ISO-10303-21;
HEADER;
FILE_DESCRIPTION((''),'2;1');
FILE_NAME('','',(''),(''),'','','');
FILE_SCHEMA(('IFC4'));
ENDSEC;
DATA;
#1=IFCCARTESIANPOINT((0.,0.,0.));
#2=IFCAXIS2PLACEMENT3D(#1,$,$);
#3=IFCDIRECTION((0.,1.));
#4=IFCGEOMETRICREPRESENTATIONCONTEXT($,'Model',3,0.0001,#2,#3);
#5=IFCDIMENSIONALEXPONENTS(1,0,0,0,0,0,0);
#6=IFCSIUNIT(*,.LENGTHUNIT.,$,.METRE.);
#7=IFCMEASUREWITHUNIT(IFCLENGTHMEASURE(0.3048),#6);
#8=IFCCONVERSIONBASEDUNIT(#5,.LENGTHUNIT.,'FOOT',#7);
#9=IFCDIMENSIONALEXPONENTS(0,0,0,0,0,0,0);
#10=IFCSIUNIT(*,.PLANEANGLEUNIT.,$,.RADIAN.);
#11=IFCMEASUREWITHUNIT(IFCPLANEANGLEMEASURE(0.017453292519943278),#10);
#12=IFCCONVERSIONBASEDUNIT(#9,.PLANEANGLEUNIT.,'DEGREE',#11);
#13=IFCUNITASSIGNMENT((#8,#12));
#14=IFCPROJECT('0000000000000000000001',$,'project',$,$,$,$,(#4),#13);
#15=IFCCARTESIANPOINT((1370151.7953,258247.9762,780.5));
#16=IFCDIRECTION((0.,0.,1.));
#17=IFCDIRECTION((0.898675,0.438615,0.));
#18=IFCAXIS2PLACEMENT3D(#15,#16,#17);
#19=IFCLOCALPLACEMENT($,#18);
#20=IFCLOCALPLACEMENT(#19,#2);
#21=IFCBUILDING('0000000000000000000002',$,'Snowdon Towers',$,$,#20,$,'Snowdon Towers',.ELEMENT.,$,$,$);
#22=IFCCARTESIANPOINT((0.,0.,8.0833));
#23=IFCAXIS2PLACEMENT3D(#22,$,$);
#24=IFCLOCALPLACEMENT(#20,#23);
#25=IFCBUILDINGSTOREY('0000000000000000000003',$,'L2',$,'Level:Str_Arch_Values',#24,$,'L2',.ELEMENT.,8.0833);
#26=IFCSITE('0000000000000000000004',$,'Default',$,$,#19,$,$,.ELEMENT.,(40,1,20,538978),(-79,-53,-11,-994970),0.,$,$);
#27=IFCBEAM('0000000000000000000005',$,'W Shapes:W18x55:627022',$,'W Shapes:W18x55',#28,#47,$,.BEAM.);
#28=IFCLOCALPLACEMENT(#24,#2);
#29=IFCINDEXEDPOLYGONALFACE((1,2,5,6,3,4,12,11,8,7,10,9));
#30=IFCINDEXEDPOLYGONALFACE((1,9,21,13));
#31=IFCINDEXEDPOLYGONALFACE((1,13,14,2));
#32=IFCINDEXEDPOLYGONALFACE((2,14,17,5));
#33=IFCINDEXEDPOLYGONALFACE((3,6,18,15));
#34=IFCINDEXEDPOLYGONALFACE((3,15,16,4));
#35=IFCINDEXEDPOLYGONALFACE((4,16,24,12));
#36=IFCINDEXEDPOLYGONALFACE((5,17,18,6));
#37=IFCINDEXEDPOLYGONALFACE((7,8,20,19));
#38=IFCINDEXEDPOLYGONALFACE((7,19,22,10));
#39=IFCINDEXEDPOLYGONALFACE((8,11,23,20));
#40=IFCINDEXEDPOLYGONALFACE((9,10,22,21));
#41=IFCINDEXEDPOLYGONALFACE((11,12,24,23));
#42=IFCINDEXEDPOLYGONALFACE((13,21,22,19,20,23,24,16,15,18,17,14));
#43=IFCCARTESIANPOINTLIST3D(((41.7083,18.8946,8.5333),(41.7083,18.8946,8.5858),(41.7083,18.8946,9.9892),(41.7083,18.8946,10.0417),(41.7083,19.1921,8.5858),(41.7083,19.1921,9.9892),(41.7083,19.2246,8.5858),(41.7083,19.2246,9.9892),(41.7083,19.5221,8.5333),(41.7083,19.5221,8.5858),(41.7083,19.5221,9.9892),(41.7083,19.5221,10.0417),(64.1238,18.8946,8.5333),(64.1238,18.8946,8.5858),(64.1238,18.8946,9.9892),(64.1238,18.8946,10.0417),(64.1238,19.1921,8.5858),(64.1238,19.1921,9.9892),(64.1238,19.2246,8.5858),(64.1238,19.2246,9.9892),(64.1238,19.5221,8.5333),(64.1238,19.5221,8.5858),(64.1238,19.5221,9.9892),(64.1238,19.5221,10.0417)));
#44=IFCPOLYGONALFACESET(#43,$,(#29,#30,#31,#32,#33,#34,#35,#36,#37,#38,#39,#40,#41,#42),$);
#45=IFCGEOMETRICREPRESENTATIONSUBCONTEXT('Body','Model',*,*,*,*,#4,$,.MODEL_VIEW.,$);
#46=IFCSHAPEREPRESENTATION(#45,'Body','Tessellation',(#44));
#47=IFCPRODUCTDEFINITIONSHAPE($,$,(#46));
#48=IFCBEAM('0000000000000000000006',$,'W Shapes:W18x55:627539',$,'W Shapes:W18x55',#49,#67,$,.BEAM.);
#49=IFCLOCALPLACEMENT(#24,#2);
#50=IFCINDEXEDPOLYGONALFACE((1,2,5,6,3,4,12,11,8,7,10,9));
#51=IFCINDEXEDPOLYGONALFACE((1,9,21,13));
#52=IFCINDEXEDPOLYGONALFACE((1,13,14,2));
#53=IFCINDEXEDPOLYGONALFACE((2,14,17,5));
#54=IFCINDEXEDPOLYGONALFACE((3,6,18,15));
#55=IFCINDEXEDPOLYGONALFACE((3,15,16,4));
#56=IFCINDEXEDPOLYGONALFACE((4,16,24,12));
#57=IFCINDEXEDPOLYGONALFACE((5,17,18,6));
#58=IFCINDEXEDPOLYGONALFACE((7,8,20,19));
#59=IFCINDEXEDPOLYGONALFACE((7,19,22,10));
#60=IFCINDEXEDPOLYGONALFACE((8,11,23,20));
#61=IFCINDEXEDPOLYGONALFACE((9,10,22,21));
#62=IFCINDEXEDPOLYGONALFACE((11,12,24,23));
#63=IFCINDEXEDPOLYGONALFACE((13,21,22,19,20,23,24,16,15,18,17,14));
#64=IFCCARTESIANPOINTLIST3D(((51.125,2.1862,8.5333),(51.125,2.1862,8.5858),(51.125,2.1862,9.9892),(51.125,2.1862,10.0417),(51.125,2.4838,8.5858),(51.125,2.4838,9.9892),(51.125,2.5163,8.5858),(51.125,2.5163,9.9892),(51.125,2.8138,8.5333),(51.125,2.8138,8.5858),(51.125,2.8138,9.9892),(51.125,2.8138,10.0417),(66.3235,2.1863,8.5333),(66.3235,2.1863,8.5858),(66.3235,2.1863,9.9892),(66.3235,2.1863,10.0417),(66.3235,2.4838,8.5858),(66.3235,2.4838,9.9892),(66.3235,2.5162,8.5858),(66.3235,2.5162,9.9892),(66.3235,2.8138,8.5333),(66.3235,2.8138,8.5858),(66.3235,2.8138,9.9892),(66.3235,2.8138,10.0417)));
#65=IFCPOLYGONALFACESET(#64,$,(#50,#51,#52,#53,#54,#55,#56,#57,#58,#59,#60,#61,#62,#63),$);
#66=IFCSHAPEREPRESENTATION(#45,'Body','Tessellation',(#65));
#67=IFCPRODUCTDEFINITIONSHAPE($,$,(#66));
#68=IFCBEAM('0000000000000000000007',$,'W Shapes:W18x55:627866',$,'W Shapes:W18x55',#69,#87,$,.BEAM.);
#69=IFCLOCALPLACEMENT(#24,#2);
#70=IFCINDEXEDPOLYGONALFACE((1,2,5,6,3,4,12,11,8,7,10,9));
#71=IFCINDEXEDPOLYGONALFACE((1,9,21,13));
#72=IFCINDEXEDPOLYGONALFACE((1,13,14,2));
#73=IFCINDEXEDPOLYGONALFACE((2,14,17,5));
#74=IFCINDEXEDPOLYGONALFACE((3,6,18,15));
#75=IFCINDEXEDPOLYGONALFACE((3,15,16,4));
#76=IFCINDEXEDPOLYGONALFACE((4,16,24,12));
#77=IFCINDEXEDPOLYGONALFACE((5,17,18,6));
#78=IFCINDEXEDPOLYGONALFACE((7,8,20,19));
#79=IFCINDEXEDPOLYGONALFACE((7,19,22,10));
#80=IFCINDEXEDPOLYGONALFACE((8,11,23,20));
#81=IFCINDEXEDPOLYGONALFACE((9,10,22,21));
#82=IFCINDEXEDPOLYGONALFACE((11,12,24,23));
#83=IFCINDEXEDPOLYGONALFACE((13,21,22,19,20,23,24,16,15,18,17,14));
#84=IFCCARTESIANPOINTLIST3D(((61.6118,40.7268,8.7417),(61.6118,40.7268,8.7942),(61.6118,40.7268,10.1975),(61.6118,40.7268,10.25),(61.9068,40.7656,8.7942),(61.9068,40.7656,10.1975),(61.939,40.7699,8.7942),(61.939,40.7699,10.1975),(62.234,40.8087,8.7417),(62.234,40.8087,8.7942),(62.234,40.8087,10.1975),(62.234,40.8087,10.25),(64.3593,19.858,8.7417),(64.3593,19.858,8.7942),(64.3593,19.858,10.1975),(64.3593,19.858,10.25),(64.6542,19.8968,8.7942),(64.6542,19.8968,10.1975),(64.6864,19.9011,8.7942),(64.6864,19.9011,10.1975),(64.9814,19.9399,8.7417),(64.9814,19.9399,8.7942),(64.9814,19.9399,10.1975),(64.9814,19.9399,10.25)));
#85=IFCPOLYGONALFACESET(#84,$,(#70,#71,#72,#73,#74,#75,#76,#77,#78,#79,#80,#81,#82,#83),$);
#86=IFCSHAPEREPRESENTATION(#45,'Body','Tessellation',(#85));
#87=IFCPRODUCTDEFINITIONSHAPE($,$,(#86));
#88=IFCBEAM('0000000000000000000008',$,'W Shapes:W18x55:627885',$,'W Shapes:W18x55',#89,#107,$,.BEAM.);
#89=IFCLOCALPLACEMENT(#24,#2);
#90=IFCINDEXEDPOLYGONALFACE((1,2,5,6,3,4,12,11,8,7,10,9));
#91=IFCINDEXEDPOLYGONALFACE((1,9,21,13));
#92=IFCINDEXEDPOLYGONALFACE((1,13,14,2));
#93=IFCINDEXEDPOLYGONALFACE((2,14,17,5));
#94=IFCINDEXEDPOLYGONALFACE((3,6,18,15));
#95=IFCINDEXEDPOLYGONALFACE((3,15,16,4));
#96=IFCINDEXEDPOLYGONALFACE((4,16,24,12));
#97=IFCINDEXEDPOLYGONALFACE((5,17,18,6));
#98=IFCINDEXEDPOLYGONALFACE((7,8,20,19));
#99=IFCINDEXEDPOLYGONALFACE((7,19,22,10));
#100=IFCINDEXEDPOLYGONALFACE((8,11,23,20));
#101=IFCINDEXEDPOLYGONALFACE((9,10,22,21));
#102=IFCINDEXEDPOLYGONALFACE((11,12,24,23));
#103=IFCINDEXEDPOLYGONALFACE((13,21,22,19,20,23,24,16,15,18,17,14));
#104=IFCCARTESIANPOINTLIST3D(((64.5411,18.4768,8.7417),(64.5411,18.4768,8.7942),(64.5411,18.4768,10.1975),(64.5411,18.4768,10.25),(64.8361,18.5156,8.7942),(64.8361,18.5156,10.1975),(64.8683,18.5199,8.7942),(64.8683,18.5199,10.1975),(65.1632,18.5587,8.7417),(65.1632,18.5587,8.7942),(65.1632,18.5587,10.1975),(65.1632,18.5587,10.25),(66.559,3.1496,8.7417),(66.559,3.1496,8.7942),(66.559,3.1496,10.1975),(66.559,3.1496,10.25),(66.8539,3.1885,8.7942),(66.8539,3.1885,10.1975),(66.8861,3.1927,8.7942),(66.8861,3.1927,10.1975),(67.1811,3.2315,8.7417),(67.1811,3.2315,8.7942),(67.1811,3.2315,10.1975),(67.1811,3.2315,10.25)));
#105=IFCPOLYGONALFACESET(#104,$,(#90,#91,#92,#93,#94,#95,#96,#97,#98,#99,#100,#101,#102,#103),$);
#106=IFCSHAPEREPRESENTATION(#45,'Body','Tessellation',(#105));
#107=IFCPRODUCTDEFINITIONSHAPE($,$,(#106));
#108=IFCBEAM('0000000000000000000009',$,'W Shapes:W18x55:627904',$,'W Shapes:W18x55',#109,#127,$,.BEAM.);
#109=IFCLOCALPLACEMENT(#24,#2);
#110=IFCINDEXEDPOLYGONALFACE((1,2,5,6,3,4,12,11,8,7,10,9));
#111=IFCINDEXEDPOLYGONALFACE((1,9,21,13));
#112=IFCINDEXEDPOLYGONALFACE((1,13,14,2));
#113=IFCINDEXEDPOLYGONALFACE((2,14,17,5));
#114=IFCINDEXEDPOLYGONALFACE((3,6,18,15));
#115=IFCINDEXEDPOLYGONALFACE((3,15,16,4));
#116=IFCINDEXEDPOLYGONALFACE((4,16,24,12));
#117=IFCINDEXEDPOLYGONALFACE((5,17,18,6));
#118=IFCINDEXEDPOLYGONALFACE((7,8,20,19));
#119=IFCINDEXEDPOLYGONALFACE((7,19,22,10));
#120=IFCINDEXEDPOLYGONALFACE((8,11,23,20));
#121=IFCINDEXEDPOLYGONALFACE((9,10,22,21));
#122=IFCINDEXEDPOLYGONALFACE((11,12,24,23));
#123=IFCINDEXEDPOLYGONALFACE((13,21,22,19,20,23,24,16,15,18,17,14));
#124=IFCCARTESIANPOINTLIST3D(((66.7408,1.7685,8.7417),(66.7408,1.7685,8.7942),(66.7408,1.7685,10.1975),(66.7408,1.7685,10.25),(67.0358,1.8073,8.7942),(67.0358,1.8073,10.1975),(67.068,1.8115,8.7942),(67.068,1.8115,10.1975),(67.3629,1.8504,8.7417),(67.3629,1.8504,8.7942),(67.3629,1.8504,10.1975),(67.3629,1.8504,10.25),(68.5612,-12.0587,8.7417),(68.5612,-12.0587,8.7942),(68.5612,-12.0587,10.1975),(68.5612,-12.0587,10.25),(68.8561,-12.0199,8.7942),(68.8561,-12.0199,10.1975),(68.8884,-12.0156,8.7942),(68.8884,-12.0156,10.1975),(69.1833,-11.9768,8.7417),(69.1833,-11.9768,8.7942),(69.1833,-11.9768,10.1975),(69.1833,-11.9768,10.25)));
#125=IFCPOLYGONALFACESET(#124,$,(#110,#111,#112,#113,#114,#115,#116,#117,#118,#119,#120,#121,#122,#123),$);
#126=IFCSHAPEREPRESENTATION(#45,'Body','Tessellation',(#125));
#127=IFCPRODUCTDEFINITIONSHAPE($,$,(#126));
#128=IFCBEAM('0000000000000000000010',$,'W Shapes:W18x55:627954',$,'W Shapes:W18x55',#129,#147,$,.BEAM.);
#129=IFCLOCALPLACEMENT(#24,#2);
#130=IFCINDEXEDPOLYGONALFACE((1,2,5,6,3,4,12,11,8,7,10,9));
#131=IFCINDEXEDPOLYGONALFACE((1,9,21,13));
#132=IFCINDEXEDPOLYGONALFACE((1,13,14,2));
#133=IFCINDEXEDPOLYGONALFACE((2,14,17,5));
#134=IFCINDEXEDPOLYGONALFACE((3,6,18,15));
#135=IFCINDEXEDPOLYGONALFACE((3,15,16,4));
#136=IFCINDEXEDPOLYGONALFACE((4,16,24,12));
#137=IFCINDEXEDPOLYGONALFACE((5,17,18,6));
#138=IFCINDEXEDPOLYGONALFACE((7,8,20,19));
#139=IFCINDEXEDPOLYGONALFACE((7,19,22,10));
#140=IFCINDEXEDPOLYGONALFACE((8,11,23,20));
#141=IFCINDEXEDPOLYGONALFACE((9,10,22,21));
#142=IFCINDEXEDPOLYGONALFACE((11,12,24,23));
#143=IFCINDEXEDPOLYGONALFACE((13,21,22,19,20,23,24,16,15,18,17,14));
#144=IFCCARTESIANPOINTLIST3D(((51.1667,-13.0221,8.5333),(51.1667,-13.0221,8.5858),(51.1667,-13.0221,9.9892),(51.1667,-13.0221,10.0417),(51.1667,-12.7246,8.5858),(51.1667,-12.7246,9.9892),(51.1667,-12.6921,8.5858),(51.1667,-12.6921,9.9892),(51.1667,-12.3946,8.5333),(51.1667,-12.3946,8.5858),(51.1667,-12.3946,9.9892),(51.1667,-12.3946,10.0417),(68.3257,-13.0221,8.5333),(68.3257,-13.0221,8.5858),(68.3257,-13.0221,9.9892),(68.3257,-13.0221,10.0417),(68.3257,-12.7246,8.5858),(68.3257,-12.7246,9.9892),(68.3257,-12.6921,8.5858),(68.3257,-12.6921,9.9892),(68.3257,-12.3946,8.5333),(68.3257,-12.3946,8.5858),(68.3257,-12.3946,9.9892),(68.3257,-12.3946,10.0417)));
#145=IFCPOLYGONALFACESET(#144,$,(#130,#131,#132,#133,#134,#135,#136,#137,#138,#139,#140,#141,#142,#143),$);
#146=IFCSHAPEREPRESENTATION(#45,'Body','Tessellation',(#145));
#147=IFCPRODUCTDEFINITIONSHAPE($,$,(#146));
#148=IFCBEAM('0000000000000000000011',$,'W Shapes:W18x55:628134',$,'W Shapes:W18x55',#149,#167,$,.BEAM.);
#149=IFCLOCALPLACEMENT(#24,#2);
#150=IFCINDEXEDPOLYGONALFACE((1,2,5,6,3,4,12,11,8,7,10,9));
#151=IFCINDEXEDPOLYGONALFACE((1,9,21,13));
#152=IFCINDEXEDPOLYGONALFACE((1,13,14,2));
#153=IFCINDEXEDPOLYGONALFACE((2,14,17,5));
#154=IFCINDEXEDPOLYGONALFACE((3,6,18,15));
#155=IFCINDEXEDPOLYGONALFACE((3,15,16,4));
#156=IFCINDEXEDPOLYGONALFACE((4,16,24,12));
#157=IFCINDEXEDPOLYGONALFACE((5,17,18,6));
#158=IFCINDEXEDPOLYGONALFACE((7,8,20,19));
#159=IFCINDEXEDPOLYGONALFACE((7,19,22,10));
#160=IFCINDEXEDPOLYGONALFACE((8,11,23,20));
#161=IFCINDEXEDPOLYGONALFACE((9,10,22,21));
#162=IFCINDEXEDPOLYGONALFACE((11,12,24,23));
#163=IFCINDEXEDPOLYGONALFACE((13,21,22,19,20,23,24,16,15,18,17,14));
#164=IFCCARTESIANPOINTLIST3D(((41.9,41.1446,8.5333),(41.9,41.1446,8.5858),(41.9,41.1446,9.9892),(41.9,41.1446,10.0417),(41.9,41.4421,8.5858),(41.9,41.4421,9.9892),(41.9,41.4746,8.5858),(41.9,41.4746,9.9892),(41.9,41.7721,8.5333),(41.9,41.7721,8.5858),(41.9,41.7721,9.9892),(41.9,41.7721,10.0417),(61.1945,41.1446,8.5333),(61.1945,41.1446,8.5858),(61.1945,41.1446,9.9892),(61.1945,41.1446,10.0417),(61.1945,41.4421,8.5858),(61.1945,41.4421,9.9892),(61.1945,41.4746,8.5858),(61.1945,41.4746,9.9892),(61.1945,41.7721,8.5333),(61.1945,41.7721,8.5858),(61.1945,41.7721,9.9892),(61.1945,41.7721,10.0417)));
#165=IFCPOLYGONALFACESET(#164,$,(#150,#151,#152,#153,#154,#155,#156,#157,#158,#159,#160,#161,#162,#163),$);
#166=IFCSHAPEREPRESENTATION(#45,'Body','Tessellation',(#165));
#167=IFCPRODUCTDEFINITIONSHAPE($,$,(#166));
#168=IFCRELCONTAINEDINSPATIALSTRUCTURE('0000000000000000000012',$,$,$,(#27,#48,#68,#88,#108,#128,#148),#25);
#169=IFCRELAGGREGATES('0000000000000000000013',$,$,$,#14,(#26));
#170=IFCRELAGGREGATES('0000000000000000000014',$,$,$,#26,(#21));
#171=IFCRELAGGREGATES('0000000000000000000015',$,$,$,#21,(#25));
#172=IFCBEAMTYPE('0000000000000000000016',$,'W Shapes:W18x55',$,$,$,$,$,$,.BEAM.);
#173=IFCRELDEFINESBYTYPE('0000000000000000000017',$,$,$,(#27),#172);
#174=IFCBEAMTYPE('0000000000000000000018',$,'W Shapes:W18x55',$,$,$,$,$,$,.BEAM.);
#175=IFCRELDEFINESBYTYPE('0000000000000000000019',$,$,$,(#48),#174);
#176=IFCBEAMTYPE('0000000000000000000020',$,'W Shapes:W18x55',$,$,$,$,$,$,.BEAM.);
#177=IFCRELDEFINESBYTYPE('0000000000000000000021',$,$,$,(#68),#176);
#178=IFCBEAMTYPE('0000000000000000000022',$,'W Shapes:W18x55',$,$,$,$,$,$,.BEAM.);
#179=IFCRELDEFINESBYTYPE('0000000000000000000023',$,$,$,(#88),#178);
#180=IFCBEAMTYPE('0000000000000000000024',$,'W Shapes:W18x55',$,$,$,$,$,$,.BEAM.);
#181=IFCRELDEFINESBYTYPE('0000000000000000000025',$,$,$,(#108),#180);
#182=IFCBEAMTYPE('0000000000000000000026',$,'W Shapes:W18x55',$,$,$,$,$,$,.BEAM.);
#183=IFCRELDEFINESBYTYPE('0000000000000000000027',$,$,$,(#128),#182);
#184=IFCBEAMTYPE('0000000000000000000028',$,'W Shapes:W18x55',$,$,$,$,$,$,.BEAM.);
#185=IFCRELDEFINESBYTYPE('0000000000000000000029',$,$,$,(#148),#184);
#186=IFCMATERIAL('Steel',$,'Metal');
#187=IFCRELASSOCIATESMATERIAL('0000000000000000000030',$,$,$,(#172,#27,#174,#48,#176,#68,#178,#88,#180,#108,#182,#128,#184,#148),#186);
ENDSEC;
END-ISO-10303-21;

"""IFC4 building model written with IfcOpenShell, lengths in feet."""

from ifc_helpers import new_model, entity, si_unit, converted_unit, direction, frame, origin, place, context, subcontext, project, spatial, indexed_curve, outline, extrude, source, transform, mapped, material, type_object, type_shapes, element, save


model = new_model("IFC4")

# Units and contexts
model_context = context("Model", 3, precision=0.0001, world=origin(), true_north=direction((0.0, 1.0)))
body_context = subcontext(model_context, "Body", "Model", "MODEL_VIEW")
ifc_project = project(units=[converted_unit("LENGTHUNIT", "FOOT", entity("IfcLengthMeasure", 0.3048), si_unit("LENGTHUNIT", "METRE"), dimensions=[1, 0, 0, 0, 0, 0, 0]), converted_unit("PLANEANGLEUNIT", "DEGREE", entity("IfcPlaneAngleMeasure", 0.017453292519943278), si_unit("PLANEANGLEUNIT", "RADIAN"), dimensions=[0, 0, 0, 0, 0, 0, 0])], contexts=[model_context])

# Site, building, storey
site_placement = place(None, frame((1370151.7953, 258247.9762, 780.5), z_axis=(0.0, 0.0, 1.0), x_axis=(0.898675, 0.438615, 0.0)))
site = spatial("IfcSite", under=ifc_project, at=site_placement, Name="Default", CompositionType="ELEMENT", RefLatitude=(40, 1, 20, 538978), RefLongitude=(-79, -53, -11, -994970), RefElevation=0.0)
building_placement = place(site_placement, origin())
building = spatial("IfcBuilding", under=site, at=building_placement, Name="Snowdon Towers", LongName="Snowdon Towers", CompositionType="ELEMENT")
storey_placement = place(building_placement, frame((0.0, 0.0, 8.0833)))
storey = spatial("IfcBuildingStorey", under=building, at=storey_placement, Name="L2", ObjectType="Level:Str_Arch_Values", LongName="L2", CompositionType="ELEMENT", Elevation=8.0833)

# Shared definitions
ifc_material = material(Name="Steel", Category="Metal")

# Beams
beam_type_1 = type_object("IfcBeamType", Name="W Shapes:W18x55", PredefinedType="BEAM", material=ifc_material)
shared_shape_1 = source(origin(), body_context, "Body", "SweptSolid", [
    extrude(outline(indexed_curve([(-0.3138, -0.7017), (-0.3138, -0.7542), (0.3138, -0.7542), (0.3138, -0.7017), (0.0162, -0.7017), (0.0162, 0.7017), (0.3138, 0.7017), (0.3138, 0.7542), (-0.3137, 0.7542), (-0.3137, 0.7017), (-0.0163, 0.7017), (-0.0163, -0.7017), (-0.3138, -0.7017)], self_intersect=False)), frame((-11.5915, 0.0, 0.0), z_axis=(-1.0, 0.0, 0.0), x_axis=(0.0, -1.0, 0.0)), (0.0, 0.0, -1.0), 22.4154),
])
type_shapes(beam_type_1, [shared_shape_1])
beam_1_placement = place(storey_placement, frame((53.2998, 19.2083, 9.2875)))
element("IfcBeam", 1, at=beam_1_placement, inside=storey, type_object=beam_type_1, material=ifc_material, Name="W Shapes:W18x55:627022", ObjectType="W Shapes:W18x55", PredefinedType="BEAM", context=body_context, shape_type="MappedRepresentation", body=[
    mapped(shared_shape_1, transform((0.0, 0.0, 0.0), scale=1.0)),
])
beam_type_2 = type_object("IfcBeamType", Name="W Shapes:W18x55", PredefinedType="BEAM", material=ifc_material)
shared_shape_2 = source(origin(), body_context, "Body", "SweptSolid", [
    extrude(outline(indexed_curve([(-0.3138, -0.7017), (-0.3138, -0.7542), (0.3138, -0.7542), (0.3138, -0.7017), (0.0162, -0.7017), (0.0162, 0.7017), (0.3138, 0.7017), (0.3138, 0.7542), (-0.3137, 0.7542), (-0.3137, 0.7017), (-0.0163, 0.7017), (-0.0163, -0.7017), (-0.3138, -0.7017)], self_intersect=False)), frame((-8.2122, 0.0, 0.0), z_axis=(-1.0, 0.0, 0.0), x_axis=(0.0, -1.0, 0.0)), (0.0, 0.0, -1.0), 15.1985),
])
type_shapes(beam_type_2, [shared_shape_2])
beam_2_placement = place(storey_placement, frame((59.3372, 2.5, 9.2875)))
element("IfcBeam", 2, at=beam_2_placement, inside=storey, type_object=beam_type_2, material=ifc_material, Name="W Shapes:W18x55:627539", ObjectType="W Shapes:W18x55", PredefinedType="BEAM", context=body_context, shape_type="MappedRepresentation", body=[
    mapped(shared_shape_2, transform((0.0, 0.0, 0.0), scale=1.0)),
])
beam_type_3 = type_object("IfcBeamType", Name="W Shapes:W18x55", PredefinedType="BEAM", material=ifc_material)
shared_shape_3 = source(origin(), body_context, "Body", "SweptSolid", [
    extrude(outline(indexed_curve([(-0.3138, -0.7017), (-0.3138, -0.7542), (0.3138, -0.7542), (0.3138, -0.7017), (0.0162, -0.7017), (0.0162, 0.7017), (0.3138, 0.7017), (0.3138, 0.7542), (-0.3137, 0.7542), (-0.3137, 0.7017), (-0.0163, 0.7017), (-0.0163, -0.7017), (-0.3138, -0.7017)], self_intersect=False)), frame((-10.5172, 0.0, 0.0), z_axis=(-1.0, 0.0, 0.0), x_axis=(0.0, -1.0, 0.0)), (0.0, 0.0, -1.0), 21.0489),
])
type_shapes(beam_type_3, [shared_shape_3])
beam_3_placement = place(storey_placement, frame((63.2957, 30.3405, 9.4958), z_axis=(0.0, 0.0, 1.0), x_axis=(0.130526, -0.991445, 0.0)))
element("IfcBeam", 3, at=beam_3_placement, inside=storey, type_object=beam_type_3, material=ifc_material, Name="W Shapes:W18x55:627866", ObjectType="W Shapes:W18x55", PredefinedType="BEAM", context=body_context, shape_type="MappedRepresentation", body=[
    mapped(shared_shape_3, transform((0.0, 0.0, 0.0), scale=1.0)),
])
beam_type_4 = type_object("IfcBeamType", Name="W Shapes:W18x55", PredefinedType="BEAM", material=ifc_material)
shared_shape_4 = source(origin(), body_context, "Body", "SweptSolid", [
    extrude(outline(indexed_curve([(-0.3138, -0.7017), (-0.3138, -0.7542), (0.3138, -0.7542), (0.3138, -0.7017), (0.0162, -0.7017), (0.0162, 0.7017), (0.3138, 0.7017), (0.3138, 0.7542), (-0.3137, 0.7542), (-0.3137, 0.7017), (-0.0163, 0.7017), (-0.0163, -0.7017), (-0.3138, -0.7017)], self_intersect=False)), frame((-7.8065, 0.0, 0.0), z_axis=(-1.0, 0.0, 0.0), x_axis=(0.0, -1.0, 0.0)), (0.0, 0.0, -1.0), 15.4594),
])
type_shapes(beam_type_4, [shared_shape_4])
beam_4_placement = place(storey_placement, frame((65.8711, 10.778, 9.4958), z_axis=(0.0, 0.0, 1.0), x_axis=(0.130526, -0.991445, 0.0)))
element("IfcBeam", 4, at=beam_4_placement, inside=storey, type_object=beam_type_4, material=ifc_material, Name="W Shapes:W18x55:627885", ObjectType="W Shapes:W18x55", PredefinedType="BEAM", context=body_context, shape_type="MappedRepresentation", body=[
    mapped(shared_shape_4, transform((0.0, 0.0, 0.0), scale=1.0)),
])
beam_type_5 = type_object("IfcBeamType", Name="W Shapes:W18x55", PredefinedType="BEAM", material=ifc_material)
shared_shape_5 = source(origin(), body_context, "Body", "SweptSolid", [
    extrude(outline(indexed_curve([(-0.3138, -0.7017), (-0.3138, -0.7542), (0.3138, -0.7542), (0.3138, -0.7017), (0.0162, -0.7017), (0.0162, 0.7017), (0.3138, 0.7017), (0.3138, 0.7542), (-0.3137, 0.7542), (-0.3137, 0.7017), (-0.0163, 0.7017), (-0.0163, -0.7017), (-0.3138, -0.7017)], self_intersect=False)), frame((-7.05, 0.0, 0.0), z_axis=(-1.0, 0.0, 0.0), x_axis=(0.0, -1.0, 0.0)), (0.0, 0.0, -1.0), 13.9465),
])
type_shapes(beam_type_5, [shared_shape_5])
beam_5_placement = place(storey_placement, frame((67.9721, -5.1803, 9.4958), z_axis=(0.0, 0.0, 1.0), x_axis=(0.130526, -0.991445, 0.0)))
element("IfcBeam", 5, at=beam_5_placement, inside=storey, type_object=beam_type_5, material=ifc_material, Name="W Shapes:W18x55:627904", ObjectType="W Shapes:W18x55", PredefinedType="BEAM", context=body_context, shape_type="MappedRepresentation", body=[
    mapped(shared_shape_5, transform((0.0, 0.0, 0.0), scale=1.0)),
])
beam_type_6 = type_object("IfcBeamType", Name="W Shapes:W18x55", PredefinedType="BEAM", material=ifc_material)
shared_shape_6 = source(origin(), body_context, "Body", "SweptSolid", [
    extrude(outline(indexed_curve([(-0.3138, -0.7017), (-0.3138, -0.7542), (0.3138, -0.7542), (0.3138, -0.7017), (0.0162, -0.7017), (0.0162, 0.7017), (0.3138, 0.7017), (0.3138, 0.7542), (-0.3137, 0.7542), (-0.3137, 0.7017), (-0.0163, 0.7017), (-0.0163, -0.7017), (-0.3138, -0.7017)], self_intersect=False)), frame((-8.9216, 0.0, 0.0), z_axis=(-1.0, 0.0, 0.0), x_axis=(0.0, -1.0, 0.0)), (0.0, 0.0, -1.0), 17.159),
])
type_shapes(beam_type_6, [shared_shape_6])
beam_6_placement = place(storey_placement, frame((60.0883, -12.7083, 9.2875)))
element("IfcBeam", 6, at=beam_6_placement, inside=storey, type_object=beam_type_6, material=ifc_material, Name="W Shapes:W18x55:627954", ObjectType="W Shapes:W18x55", PredefinedType="BEAM", context=body_context, shape_type="MappedRepresentation", body=[
    mapped(shared_shape_6, transform((0.0, 0.0, 0.0), scale=1.0)),
])
beam_type_7 = type_object("IfcBeamType", Name="W Shapes:W18x55", PredefinedType="BEAM", material=ifc_material)
shared_shape_7 = source(origin(), body_context, "Body", "SweptSolid", [
    extrude(outline(indexed_curve([(-0.3138, -0.7017), (-0.3138, -0.7542), (0.3138, -0.7542), (0.3138, -0.7017), (0.0162, -0.7017), (0.0162, 0.7017), (0.3138, 0.7017), (0.3138, 0.7542), (-0.3137, 0.7542), (-0.3137, 0.7017), (-0.0163, 0.7017), (-0.0163, -0.7017), (-0.3138, -0.7017)], self_intersect=False)), frame((-9.9242, 0.0, 0.0), z_axis=(-1.0, 0.0, 0.0), x_axis=(0.0, -1.0, 0.0)), (0.0, 0.0, -1.0), 19.2945),
])
type_shapes(beam_type_7, [shared_shape_7])
beam_7_placement = place(storey_placement, frame((51.8242, 41.4583, 9.2875)))
element("IfcBeam", 7, at=beam_7_placement, inside=storey, type_object=beam_type_7, material=ifc_material, Name="W Shapes:W18x55:628134", ObjectType="W Shapes:W18x55", PredefinedType="BEAM", context=body_context, shape_type="MappedRepresentation", body=[
    mapped(shared_shape_7, transform((0.0, 0.0, 0.0), scale=1.0)),
])

save(model, "model.ifc")
